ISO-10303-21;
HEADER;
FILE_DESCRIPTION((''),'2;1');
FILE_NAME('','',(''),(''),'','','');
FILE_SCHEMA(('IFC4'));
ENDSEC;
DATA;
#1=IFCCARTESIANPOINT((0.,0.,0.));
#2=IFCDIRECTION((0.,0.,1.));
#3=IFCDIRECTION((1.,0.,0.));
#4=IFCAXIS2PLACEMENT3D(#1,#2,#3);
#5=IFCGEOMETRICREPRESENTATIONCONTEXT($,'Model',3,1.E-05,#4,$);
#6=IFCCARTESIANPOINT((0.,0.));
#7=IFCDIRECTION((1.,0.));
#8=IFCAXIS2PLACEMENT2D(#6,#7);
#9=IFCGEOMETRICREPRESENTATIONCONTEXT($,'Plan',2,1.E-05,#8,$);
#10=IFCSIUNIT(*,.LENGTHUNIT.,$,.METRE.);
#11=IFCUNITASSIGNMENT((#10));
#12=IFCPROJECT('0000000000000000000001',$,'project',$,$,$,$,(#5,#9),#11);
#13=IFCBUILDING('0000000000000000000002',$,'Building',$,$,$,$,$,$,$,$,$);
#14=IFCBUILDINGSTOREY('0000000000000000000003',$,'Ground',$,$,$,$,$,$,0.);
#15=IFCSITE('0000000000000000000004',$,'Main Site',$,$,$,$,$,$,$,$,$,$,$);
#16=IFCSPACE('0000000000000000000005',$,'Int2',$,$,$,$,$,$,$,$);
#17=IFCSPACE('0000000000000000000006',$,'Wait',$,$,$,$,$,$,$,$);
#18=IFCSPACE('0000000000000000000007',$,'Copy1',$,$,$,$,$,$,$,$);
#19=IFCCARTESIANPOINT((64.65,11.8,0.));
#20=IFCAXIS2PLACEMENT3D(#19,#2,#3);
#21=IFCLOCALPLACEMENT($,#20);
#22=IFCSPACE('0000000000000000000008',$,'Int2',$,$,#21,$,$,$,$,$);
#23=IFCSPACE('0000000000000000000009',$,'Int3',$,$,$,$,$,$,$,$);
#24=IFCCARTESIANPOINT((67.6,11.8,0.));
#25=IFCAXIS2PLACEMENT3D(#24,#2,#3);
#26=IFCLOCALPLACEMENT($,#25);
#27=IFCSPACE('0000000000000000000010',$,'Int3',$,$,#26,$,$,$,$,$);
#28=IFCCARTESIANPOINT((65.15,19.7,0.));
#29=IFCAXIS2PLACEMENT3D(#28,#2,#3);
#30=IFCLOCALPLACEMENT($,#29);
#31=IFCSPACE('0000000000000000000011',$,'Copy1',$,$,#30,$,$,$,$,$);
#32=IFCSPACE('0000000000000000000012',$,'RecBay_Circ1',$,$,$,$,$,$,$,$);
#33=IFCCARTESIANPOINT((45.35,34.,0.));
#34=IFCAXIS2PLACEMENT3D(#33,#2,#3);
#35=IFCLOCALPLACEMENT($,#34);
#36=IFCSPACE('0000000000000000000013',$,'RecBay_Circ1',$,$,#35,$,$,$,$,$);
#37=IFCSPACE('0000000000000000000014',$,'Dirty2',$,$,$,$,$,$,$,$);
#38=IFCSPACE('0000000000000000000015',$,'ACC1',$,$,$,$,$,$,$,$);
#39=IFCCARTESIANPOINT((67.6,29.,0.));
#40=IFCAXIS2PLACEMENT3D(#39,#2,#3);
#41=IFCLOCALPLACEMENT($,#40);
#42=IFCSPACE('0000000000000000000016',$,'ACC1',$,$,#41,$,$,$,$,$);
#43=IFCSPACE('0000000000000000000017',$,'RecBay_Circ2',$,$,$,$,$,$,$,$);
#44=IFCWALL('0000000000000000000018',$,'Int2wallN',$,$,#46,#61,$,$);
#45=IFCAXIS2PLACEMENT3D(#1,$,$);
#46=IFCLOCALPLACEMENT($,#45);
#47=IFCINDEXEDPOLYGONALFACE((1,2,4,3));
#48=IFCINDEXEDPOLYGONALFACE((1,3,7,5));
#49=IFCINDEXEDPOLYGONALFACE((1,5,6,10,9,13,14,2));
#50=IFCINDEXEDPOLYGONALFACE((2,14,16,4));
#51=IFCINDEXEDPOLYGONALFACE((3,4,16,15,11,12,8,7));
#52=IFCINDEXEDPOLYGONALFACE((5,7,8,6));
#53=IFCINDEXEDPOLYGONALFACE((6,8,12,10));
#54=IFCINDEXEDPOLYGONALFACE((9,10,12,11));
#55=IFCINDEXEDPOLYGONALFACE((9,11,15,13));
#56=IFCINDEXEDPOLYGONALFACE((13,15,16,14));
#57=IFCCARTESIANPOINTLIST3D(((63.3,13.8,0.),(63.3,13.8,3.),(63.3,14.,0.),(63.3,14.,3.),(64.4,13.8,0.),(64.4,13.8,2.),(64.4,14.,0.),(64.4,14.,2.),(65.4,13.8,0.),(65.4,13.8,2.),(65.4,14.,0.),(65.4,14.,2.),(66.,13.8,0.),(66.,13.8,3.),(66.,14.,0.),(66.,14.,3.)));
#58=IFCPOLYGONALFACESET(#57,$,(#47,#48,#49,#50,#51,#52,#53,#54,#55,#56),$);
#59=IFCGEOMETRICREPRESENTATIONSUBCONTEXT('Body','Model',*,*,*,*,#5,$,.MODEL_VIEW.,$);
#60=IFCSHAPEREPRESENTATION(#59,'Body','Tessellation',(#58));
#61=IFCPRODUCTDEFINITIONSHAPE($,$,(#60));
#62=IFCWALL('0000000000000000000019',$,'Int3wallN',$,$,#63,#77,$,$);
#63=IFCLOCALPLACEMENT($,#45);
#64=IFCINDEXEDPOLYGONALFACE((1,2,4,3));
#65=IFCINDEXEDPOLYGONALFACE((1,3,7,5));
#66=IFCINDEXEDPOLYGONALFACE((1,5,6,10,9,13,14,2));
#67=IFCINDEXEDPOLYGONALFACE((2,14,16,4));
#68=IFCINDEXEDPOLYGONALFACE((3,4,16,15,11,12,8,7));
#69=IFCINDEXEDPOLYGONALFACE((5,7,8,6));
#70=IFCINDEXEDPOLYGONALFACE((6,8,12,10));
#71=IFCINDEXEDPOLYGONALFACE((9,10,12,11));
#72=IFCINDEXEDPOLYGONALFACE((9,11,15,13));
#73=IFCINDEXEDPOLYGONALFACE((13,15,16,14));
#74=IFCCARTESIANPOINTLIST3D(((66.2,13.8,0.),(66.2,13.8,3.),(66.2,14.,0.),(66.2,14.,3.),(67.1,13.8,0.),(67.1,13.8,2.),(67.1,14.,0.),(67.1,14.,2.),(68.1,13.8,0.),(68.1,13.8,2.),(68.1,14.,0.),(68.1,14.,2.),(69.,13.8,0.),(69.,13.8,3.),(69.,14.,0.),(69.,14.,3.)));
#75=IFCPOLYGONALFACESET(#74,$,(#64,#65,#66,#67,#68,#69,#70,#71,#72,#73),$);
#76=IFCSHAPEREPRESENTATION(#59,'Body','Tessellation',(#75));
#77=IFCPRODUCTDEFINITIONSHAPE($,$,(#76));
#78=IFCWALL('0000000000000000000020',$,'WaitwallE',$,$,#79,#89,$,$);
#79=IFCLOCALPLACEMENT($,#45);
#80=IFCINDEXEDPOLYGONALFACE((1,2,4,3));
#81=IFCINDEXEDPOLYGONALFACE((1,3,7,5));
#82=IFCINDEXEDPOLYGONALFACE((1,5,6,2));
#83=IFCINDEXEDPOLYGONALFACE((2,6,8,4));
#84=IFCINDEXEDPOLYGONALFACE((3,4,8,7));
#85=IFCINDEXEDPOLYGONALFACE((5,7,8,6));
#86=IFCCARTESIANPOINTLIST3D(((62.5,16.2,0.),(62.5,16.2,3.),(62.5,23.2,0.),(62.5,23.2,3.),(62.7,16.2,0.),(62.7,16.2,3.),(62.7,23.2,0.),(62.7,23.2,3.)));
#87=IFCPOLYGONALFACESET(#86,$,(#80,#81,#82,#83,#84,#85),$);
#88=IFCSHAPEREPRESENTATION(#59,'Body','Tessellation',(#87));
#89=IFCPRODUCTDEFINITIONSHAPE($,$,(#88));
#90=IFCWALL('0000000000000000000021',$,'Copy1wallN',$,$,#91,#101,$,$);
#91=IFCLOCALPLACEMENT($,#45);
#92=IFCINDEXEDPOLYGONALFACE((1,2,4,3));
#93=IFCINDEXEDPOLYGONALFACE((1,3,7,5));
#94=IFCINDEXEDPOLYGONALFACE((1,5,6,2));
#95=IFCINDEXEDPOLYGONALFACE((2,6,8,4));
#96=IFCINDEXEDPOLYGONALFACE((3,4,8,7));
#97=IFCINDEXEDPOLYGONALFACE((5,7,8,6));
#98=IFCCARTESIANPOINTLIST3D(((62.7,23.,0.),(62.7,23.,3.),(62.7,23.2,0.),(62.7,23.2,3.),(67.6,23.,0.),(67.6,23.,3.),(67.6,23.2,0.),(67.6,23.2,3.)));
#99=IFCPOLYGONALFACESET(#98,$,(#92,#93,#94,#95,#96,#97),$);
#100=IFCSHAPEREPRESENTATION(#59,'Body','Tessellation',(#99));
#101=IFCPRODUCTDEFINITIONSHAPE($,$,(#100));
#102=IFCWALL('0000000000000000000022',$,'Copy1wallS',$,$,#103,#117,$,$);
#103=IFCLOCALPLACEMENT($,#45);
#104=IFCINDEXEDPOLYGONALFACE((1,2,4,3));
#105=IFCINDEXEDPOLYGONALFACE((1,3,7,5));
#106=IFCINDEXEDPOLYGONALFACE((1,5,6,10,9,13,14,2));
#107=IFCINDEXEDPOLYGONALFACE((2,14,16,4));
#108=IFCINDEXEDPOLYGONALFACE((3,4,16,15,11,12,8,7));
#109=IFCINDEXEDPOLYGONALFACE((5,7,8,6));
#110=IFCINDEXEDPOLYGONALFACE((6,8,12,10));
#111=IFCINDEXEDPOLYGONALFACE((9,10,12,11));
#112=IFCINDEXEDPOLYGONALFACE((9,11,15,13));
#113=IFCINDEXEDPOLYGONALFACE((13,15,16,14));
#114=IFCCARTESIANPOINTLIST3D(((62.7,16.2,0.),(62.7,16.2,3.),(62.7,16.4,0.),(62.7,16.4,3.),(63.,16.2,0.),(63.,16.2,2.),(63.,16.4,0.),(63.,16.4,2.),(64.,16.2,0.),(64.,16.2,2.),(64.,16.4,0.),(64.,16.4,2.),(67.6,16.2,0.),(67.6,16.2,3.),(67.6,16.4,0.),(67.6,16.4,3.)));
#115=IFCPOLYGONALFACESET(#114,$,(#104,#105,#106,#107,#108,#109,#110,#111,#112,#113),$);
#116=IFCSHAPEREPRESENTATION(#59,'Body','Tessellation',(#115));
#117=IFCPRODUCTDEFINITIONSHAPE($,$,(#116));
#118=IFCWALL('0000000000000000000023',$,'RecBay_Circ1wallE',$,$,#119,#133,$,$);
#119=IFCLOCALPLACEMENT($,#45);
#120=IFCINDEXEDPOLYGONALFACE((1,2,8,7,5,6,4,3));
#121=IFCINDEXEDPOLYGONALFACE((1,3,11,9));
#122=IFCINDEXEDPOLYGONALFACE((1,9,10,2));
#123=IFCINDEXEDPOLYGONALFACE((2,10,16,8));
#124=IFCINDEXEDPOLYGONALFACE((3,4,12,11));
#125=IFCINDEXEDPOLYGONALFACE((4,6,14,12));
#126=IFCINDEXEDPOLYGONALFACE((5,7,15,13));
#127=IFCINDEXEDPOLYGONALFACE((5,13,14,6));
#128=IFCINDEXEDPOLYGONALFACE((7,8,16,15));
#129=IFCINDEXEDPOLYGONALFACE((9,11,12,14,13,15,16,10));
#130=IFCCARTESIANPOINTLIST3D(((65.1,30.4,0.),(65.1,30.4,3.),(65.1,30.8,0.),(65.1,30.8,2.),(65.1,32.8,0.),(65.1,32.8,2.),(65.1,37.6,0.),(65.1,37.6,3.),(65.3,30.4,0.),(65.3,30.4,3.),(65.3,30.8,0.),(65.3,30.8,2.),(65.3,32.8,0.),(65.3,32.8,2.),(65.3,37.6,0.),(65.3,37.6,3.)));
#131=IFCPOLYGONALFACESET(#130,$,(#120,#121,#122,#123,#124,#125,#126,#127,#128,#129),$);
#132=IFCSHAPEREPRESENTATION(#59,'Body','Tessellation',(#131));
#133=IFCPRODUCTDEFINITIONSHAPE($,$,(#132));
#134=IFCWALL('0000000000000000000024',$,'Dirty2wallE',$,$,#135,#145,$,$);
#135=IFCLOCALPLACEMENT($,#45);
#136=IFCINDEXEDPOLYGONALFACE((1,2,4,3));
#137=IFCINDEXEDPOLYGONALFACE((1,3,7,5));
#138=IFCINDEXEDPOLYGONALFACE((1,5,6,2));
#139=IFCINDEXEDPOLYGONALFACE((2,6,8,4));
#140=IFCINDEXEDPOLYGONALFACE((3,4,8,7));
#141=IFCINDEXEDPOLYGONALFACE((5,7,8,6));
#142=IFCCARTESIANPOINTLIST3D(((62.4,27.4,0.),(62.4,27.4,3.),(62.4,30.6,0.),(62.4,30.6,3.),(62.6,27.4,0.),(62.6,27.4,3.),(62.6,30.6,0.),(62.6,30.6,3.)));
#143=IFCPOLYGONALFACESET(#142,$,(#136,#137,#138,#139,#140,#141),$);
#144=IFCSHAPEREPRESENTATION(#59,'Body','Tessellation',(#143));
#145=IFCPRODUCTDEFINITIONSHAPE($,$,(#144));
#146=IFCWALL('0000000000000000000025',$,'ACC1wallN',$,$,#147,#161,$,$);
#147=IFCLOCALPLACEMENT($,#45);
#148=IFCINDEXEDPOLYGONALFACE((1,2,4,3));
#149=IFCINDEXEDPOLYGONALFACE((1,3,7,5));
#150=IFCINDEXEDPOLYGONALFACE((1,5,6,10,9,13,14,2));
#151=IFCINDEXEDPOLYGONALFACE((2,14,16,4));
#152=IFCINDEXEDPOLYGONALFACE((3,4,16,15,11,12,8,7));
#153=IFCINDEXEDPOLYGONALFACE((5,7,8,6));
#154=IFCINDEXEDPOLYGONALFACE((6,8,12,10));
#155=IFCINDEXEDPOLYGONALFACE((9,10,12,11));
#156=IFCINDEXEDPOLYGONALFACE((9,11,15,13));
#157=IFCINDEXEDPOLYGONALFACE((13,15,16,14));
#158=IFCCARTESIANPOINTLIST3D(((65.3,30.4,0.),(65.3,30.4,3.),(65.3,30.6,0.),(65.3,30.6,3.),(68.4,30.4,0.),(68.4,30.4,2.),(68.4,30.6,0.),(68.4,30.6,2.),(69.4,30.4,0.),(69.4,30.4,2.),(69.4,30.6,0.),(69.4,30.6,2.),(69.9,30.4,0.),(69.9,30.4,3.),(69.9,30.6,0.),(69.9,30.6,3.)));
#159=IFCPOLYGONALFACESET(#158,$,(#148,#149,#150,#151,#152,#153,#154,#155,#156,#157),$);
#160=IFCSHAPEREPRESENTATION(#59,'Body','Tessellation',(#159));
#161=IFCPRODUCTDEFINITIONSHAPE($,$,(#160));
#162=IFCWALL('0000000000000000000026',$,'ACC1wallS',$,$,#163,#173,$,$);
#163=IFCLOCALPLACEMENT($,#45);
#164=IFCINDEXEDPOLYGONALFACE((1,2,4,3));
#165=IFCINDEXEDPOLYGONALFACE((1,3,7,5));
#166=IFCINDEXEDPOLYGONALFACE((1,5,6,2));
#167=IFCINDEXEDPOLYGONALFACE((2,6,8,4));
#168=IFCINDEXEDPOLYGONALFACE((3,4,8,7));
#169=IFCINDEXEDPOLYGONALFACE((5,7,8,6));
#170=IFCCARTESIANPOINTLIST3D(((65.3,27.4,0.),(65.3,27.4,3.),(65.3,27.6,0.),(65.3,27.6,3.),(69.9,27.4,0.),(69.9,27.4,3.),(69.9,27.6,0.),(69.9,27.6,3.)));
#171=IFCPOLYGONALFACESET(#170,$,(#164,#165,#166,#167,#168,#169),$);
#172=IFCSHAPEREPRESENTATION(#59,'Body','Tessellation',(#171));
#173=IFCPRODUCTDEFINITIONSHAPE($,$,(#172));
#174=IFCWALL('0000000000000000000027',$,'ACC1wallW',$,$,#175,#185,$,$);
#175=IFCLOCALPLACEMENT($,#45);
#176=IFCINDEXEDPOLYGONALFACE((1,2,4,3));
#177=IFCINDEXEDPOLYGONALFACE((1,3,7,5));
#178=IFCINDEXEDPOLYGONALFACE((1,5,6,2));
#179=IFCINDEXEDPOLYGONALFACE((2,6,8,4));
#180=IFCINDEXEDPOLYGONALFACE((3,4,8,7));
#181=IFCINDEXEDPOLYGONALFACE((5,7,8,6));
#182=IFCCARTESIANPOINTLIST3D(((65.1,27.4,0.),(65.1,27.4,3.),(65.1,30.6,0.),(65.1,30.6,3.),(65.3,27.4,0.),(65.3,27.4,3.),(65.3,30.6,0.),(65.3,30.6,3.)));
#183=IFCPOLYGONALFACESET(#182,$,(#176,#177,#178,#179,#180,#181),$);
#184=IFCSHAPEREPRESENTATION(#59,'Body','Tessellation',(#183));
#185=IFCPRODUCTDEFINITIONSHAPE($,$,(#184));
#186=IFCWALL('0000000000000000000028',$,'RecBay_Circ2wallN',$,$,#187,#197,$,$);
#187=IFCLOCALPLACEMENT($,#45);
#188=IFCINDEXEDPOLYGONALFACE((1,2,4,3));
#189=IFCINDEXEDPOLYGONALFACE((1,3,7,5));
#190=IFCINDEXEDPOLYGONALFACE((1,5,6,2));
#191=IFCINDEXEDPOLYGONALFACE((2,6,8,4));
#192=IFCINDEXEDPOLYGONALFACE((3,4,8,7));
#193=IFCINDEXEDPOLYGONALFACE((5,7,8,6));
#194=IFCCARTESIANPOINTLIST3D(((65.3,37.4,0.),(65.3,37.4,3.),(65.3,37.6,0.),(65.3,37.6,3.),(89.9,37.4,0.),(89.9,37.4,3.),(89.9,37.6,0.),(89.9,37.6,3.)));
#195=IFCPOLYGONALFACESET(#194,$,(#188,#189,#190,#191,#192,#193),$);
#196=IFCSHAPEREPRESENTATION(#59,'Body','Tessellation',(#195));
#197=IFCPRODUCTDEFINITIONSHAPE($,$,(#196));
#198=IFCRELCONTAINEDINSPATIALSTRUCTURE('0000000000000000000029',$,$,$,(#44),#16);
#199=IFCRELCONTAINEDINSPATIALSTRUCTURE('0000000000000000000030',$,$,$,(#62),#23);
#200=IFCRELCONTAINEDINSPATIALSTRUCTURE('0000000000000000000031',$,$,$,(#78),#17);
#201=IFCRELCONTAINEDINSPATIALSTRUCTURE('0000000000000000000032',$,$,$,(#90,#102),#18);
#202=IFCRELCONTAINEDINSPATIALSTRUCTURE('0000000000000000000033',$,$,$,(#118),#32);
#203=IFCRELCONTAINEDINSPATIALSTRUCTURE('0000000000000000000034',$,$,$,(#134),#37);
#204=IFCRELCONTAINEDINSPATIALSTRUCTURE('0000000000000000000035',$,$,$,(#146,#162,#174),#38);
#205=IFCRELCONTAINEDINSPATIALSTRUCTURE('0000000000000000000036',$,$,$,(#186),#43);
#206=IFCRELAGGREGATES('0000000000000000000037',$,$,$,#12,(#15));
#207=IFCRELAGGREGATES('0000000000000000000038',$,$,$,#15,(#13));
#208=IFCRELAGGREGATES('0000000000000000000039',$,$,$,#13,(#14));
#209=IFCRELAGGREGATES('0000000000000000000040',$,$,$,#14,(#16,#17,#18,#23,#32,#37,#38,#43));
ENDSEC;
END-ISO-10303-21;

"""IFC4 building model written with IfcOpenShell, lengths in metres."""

from ifc_helpers import new_model, si_unit, frame, origin_with_axes, origin_2d_with_axis, place, context, subcontext, project, spatial, indexed_curve, outline, extrude, element, save


model = new_model("IFC4")

# Units and contexts
model_context = context("Model", 3, precision=1e-05, world=origin_with_axes())
plan_context = context("Plan", 2, precision=1e-05, world=origin_2d_with_axis())
body_context = subcontext(model_context, "Body", "Model", "MODEL_VIEW")
ifc_project = project(units=[si_unit("LENGTHUNIT", "METRE")], contexts=[model_context, plan_context])

# Site, building, storey
site = spatial("IfcSite", under=ifc_project, Name="Main Site")
building = spatial("IfcBuilding", under=site, Name="Building")
storey = spatial("IfcBuildingStorey", under=building, Name="Ground", Elevation=0.0)

# Shared definitions
space_1 = spatial("IfcSpace", under=storey, Name="Int2")

# Shared definitions
space_2 = spatial("IfcSpace", under=storey, Name="Wait")

# Shared definitions
space_3 = spatial("IfcSpace", under=storey, Name="Copy1")

# Wall
wall_1_placement = place(None, frame((63.3, 13.8, 0.0), z_axis=(0.0, 0.0, 1.0), x_axis=(1.0, 0.0, 0.0)))
wall_1 = element("IfcWall", 1, at=wall_1_placement, inside=space_1, Name="Int2wallN", context=body_context, shape_type="SweptSolid", body=[
    extrude(outline(indexed_curve([(0.0, 0.0), (0.0, 0.2), (2.7, 0.2), (2.7, 0.0), (0.0, 0.0)], self_intersect=False)), origin_with_axes(), (0.0, 0.0, 1.0), 3.0),
])

# Shared definitions
space_4_placement = place(None, frame((64.65, 11.8, 0.0), z_axis=(0.0, 0.0, 1.0), x_axis=(1.0, 0.0, 0.0)))
space_4 = spatial("IfcSpace", at=space_4_placement, Name="Int2")

# Opening
opening_1_placement = place(wall_1_placement, frame((1.1, 0.0, 0.0), z_axis=(0.0, 0.0, 1.0), x_axis=(1.0, 0.0, 0.0)))
element("IfcOpeningElement", 2, at=opening_1_placement, inside=space_4, cuts=wall_1, context=body_context, shape_type="SweptSolid", body=[
    extrude(outline(indexed_curve([(0.0, 0.0), (0.0, 0.4), (1.0, 0.4), (1.0, 0.0), (0.0, 0.0)], self_intersect=False)), origin_with_axes(), (0.0, 0.0, 1.0), 2.0),
])

# Shared definitions
space_5 = spatial("IfcSpace", under=storey, Name="Int3")

# Wall
wall_2_placement = place(None, frame((66.2, 13.8, 0.0), z_axis=(0.0, 0.0, 1.0), x_axis=(1.0, 0.0, 0.0)))
wall_2 = element("IfcWall", 3, at=wall_2_placement, inside=space_5, Name="Int3wallN", context=body_context, shape_type="SweptSolid", body=[
    extrude(outline(indexed_curve([(0.0, 0.0), (0.0, 0.2), (2.8, 0.2), (2.8, 0.0), (0.0, 0.0)], self_intersect=False)), origin_with_axes(), (0.0, 0.0, 1.0), 3.0),
])

# Shared definitions
space_6_placement = place(None, frame((67.6, 11.8, 0.0), z_axis=(0.0, 0.0, 1.0), x_axis=(1.0, 0.0, 0.0)))
space_6 = spatial("IfcSpace", at=space_6_placement, Name="Int3")

# Opening
opening_2_placement = place(wall_2_placement, frame((0.9, 0.0, 0.0), z_axis=(0.0, 0.0, 1.0), x_axis=(1.0, 0.0, 0.0)))
element("IfcOpeningElement", 4, at=opening_2_placement, inside=space_6, cuts=wall_2, context=body_context, shape_type="SweptSolid", body=[
    extrude(outline(indexed_curve([(0.0, 0.0), (0.0, 0.4), (1.0, 0.4), (1.0, 0.0), (0.0, 0.0)], self_intersect=False)), origin_with_axes(), (0.0, 0.0, 1.0), 2.0),
])

# Walls
wall_3_placement = place(None, frame((62.7, 16.2, 0.0), z_axis=(0.0, 0.0, 1.0), x_axis=(0.0, 1.0, 0.0)))
element("IfcWall", 5, at=wall_3_placement, inside=space_2, Name="WaitwallE", context=body_context, shape_type="SweptSolid", body=[
    extrude(outline(indexed_curve([(0.0, 0.0), (0.0, 0.2), (7.0, 0.2), (7.0, 0.0), (0.0, 0.0)], self_intersect=False)), origin_with_axes(), (0.0, 0.0, 1.0), 3.0),
])
wall_4_placement = place(None, frame((62.7, 23.0, 0.0), z_axis=(0.0, 0.0, 1.0), x_axis=(1.0, 0.0, 0.0)))
element("IfcWall", 6, at=wall_4_placement, inside=space_3, Name="Copy1wallN", context=body_context, shape_type="SweptSolid", body=[
    extrude(outline(indexed_curve([(0.0, 0.0), (0.0, 0.2), (4.9, 0.2), (4.9, 0.0), (0.0, 0.0)], self_intersect=False)), origin_with_axes(), (0.0, 0.0, 1.0), 3.0),
])

# Wall
wall_5_placement = place(None, frame((62.7, 16.2, 0.0), z_axis=(0.0, 0.0, 1.0), x_axis=(1.0, 0.0, 0.0)))
wall_5 = element("IfcWall", 7, at=wall_5_placement, inside=space_3, Name="Copy1wallS", context=body_context, shape_type="SweptSolid", body=[
    extrude(outline(indexed_curve([(0.0, 0.0), (0.0, 0.2), (4.9, 0.2), (4.9, 0.0), (0.0, 0.0)], self_intersect=False)), origin_with_axes(), (0.0, 0.0, 1.0), 3.0),
])

# Shared definitions
space_7_placement = place(None, frame((65.15, 19.7, 0.0), z_axis=(0.0, 0.0, 1.0), x_axis=(1.0, 0.0, 0.0)))
space_7 = spatial("IfcSpace", at=space_7_placement, Name="Copy1")

# Opening
opening_3_placement = place(wall_5_placement, frame((0.3, 0.0, 0.0), z_axis=(0.0, 0.0, 1.0), x_axis=(1.0, 0.0, 0.0)))
element("IfcOpeningElement", 8, at=opening_3_placement, inside=space_7, cuts=wall_5, context=body_context, shape_type="SweptSolid", body=[
    extrude(outline(indexed_curve([(0.0, 0.0), (0.0, 0.4), (1.0, 0.4), (1.0, 0.0), (0.0, 0.0)], self_intersect=False)), origin_with_axes(), (0.0, 0.0, 1.0), 2.0),
])

# Shared definitions
space_8 = spatial("IfcSpace", under=storey, Name="RecBay_Circ1")

# Wall
wall_6_placement = place(None, frame((65.3, 30.4, 0.0), z_axis=(0.0, 0.0, 1.0), x_axis=(0.0, 1.0, 0.0)))
wall_6 = element("IfcWall", 9, at=wall_6_placement, inside=space_8, Name="RecBay_Circ1wallE", context=body_context, shape_type="SweptSolid", body=[
    extrude(outline(indexed_curve([(0.0, 0.0), (0.0, 0.2), (7.2, 0.2), (7.2, 0.0), (0.0, 0.0)], self_intersect=False)), origin_with_axes(), (0.0, 0.0, 1.0), 3.0),
])

# Shared definitions
space_9_placement = place(None, frame((45.35, 34.0, 0.0), z_axis=(0.0, 0.0, 1.0), x_axis=(1.0, 0.0, 0.0)))
space_9 = spatial("IfcSpace", at=space_9_placement, Name="RecBay_Circ1")

# Opening
opening_4_placement = place(wall_6_placement, frame((0.4, 0.0, 0.0), z_axis=(0.0, 0.0, 1.0), x_axis=(1.0, 0.0, 0.0)))
element("IfcOpeningElement", 10, at=opening_4_placement, inside=space_9, cuts=wall_6, context=body_context, shape_type="SweptSolid", body=[
    extrude(outline(indexed_curve([(0.0, 0.0), (0.0, 0.4), (2.0, 0.4), (2.0, 0.0), (0.0, 0.0)], self_intersect=False)), origin_with_axes(), (0.0, 0.0, 1.0), 2.0),
])

# Shared definitions
space_10 = spatial("IfcSpace", under=storey, Name="Dirty2")

# Wall
wall_7_placement = place(None, frame((62.6, 27.4, 0.0), z_axis=(0.0, 0.0, 1.0), x_axis=(0.0, 1.0, 0.0)))
element("IfcWall", 11, at=wall_7_placement, inside=space_10, Name="Dirty2wallE", context=body_context, shape_type="SweptSolid", body=[
    extrude(outline(indexed_curve([(0.0, 0.0), (0.0, 0.2), (3.2, 0.2), (3.2, 0.0), (0.0, 0.0)], self_intersect=False)), origin_with_axes(), (0.0, 0.0, 1.0), 3.0),
])

# Shared definitions
space_11 = spatial("IfcSpace", under=storey, Name="ACC1")

# Wall
wall_8_placement = place(None, frame((65.3, 30.4, 0.0), z_axis=(0.0, 0.0, 1.0), x_axis=(1.0, 0.0, 0.0)))
wall_8 = element("IfcWall", 12, at=wall_8_placement, inside=space_11, Name="ACC1wallN", context=body_context, shape_type="SweptSolid", body=[
    extrude(outline(indexed_curve([(0.0, 0.0), (0.0, 0.2), (4.6, 0.2), (4.6, 0.0), (0.0, 0.0)], self_intersect=False)), origin_with_axes(), (0.0, 0.0, 1.0), 3.0),
])

# Shared definitions
space_12_placement = place(None, frame((67.6, 29.0, 0.0), z_axis=(0.0, 0.0, 1.0), x_axis=(1.0, 0.0, 0.0)))
space_12 = spatial("IfcSpace", at=space_12_placement, Name="ACC1")

# Opening
opening_5_placement = place(wall_8_placement, frame((3.1, 0.0, 0.0), z_axis=(0.0, 0.0, 1.0), x_axis=(1.0, 0.0, 0.0)))
element("IfcOpeningElement", 13, at=opening_5_placement, inside=space_12, cuts=wall_8, context=body_context, shape_type="SweptSolid", body=[
    extrude(outline(indexed_curve([(0.0, 0.0), (0.0, 0.4), (1.0, 0.4), (1.0, 0.0), (0.0, 0.0)], self_intersect=False)), origin_with_axes(), (0.0, 0.0, 1.0), 2.0),
])

# Walls
wall_9_placement = place(None, frame((65.3, 27.4, 0.0), z_axis=(0.0, 0.0, 1.0), x_axis=(1.0, 0.0, 0.0)))
element("IfcWall", 14, at=wall_9_placement, inside=space_11, Name="ACC1wallS", context=body_context, shape_type="SweptSolid", body=[
    extrude(outline(indexed_curve([(0.0, 0.0), (0.0, 0.2), (4.6, 0.2), (4.6, 0.0), (0.0, 0.0)], self_intersect=False)), origin_with_axes(), (0.0, 0.0, 1.0), 3.0),
])
wall_10_placement = place(None, frame((65.3, 27.4, 0.0), z_axis=(0.0, 0.0, 1.0), x_axis=(0.0, 1.0, 0.0)))
element("IfcWall", 15, at=wall_10_placement, inside=space_11, Name="ACC1wallW", context=body_context, shape_type="SweptSolid", body=[
    extrude(outline(indexed_curve([(0.0, 0.0), (0.0, 0.2), (3.2, 0.2), (3.2, 0.0), (0.0, 0.0)], self_intersect=False)), origin_with_axes(), (0.0, 0.0, 1.0), 3.0),
])

# Shared definitions
space_13 = spatial("IfcSpace", under=storey, Name="RecBay_Circ2")

# Wall
wall_11_placement = place(None, frame((65.3, 37.4, 0.0), z_axis=(0.0, 0.0, 1.0), x_axis=(1.0, 0.0, 0.0)))
element("IfcWall", 16, at=wall_11_placement, inside=space_13, Name="RecBay_Circ2wallN", context=body_context, shape_type="SweptSolid", body=[
    extrude(outline(indexed_curve([(0.0, 0.0), (0.0, 0.2), (24.6, 0.2), (24.6, 0.0), (0.0, 0.0)], self_intersect=False)), origin_with_axes(), (0.0, 0.0, 1.0), 3.0),
])

save(model, "model.ifc")
